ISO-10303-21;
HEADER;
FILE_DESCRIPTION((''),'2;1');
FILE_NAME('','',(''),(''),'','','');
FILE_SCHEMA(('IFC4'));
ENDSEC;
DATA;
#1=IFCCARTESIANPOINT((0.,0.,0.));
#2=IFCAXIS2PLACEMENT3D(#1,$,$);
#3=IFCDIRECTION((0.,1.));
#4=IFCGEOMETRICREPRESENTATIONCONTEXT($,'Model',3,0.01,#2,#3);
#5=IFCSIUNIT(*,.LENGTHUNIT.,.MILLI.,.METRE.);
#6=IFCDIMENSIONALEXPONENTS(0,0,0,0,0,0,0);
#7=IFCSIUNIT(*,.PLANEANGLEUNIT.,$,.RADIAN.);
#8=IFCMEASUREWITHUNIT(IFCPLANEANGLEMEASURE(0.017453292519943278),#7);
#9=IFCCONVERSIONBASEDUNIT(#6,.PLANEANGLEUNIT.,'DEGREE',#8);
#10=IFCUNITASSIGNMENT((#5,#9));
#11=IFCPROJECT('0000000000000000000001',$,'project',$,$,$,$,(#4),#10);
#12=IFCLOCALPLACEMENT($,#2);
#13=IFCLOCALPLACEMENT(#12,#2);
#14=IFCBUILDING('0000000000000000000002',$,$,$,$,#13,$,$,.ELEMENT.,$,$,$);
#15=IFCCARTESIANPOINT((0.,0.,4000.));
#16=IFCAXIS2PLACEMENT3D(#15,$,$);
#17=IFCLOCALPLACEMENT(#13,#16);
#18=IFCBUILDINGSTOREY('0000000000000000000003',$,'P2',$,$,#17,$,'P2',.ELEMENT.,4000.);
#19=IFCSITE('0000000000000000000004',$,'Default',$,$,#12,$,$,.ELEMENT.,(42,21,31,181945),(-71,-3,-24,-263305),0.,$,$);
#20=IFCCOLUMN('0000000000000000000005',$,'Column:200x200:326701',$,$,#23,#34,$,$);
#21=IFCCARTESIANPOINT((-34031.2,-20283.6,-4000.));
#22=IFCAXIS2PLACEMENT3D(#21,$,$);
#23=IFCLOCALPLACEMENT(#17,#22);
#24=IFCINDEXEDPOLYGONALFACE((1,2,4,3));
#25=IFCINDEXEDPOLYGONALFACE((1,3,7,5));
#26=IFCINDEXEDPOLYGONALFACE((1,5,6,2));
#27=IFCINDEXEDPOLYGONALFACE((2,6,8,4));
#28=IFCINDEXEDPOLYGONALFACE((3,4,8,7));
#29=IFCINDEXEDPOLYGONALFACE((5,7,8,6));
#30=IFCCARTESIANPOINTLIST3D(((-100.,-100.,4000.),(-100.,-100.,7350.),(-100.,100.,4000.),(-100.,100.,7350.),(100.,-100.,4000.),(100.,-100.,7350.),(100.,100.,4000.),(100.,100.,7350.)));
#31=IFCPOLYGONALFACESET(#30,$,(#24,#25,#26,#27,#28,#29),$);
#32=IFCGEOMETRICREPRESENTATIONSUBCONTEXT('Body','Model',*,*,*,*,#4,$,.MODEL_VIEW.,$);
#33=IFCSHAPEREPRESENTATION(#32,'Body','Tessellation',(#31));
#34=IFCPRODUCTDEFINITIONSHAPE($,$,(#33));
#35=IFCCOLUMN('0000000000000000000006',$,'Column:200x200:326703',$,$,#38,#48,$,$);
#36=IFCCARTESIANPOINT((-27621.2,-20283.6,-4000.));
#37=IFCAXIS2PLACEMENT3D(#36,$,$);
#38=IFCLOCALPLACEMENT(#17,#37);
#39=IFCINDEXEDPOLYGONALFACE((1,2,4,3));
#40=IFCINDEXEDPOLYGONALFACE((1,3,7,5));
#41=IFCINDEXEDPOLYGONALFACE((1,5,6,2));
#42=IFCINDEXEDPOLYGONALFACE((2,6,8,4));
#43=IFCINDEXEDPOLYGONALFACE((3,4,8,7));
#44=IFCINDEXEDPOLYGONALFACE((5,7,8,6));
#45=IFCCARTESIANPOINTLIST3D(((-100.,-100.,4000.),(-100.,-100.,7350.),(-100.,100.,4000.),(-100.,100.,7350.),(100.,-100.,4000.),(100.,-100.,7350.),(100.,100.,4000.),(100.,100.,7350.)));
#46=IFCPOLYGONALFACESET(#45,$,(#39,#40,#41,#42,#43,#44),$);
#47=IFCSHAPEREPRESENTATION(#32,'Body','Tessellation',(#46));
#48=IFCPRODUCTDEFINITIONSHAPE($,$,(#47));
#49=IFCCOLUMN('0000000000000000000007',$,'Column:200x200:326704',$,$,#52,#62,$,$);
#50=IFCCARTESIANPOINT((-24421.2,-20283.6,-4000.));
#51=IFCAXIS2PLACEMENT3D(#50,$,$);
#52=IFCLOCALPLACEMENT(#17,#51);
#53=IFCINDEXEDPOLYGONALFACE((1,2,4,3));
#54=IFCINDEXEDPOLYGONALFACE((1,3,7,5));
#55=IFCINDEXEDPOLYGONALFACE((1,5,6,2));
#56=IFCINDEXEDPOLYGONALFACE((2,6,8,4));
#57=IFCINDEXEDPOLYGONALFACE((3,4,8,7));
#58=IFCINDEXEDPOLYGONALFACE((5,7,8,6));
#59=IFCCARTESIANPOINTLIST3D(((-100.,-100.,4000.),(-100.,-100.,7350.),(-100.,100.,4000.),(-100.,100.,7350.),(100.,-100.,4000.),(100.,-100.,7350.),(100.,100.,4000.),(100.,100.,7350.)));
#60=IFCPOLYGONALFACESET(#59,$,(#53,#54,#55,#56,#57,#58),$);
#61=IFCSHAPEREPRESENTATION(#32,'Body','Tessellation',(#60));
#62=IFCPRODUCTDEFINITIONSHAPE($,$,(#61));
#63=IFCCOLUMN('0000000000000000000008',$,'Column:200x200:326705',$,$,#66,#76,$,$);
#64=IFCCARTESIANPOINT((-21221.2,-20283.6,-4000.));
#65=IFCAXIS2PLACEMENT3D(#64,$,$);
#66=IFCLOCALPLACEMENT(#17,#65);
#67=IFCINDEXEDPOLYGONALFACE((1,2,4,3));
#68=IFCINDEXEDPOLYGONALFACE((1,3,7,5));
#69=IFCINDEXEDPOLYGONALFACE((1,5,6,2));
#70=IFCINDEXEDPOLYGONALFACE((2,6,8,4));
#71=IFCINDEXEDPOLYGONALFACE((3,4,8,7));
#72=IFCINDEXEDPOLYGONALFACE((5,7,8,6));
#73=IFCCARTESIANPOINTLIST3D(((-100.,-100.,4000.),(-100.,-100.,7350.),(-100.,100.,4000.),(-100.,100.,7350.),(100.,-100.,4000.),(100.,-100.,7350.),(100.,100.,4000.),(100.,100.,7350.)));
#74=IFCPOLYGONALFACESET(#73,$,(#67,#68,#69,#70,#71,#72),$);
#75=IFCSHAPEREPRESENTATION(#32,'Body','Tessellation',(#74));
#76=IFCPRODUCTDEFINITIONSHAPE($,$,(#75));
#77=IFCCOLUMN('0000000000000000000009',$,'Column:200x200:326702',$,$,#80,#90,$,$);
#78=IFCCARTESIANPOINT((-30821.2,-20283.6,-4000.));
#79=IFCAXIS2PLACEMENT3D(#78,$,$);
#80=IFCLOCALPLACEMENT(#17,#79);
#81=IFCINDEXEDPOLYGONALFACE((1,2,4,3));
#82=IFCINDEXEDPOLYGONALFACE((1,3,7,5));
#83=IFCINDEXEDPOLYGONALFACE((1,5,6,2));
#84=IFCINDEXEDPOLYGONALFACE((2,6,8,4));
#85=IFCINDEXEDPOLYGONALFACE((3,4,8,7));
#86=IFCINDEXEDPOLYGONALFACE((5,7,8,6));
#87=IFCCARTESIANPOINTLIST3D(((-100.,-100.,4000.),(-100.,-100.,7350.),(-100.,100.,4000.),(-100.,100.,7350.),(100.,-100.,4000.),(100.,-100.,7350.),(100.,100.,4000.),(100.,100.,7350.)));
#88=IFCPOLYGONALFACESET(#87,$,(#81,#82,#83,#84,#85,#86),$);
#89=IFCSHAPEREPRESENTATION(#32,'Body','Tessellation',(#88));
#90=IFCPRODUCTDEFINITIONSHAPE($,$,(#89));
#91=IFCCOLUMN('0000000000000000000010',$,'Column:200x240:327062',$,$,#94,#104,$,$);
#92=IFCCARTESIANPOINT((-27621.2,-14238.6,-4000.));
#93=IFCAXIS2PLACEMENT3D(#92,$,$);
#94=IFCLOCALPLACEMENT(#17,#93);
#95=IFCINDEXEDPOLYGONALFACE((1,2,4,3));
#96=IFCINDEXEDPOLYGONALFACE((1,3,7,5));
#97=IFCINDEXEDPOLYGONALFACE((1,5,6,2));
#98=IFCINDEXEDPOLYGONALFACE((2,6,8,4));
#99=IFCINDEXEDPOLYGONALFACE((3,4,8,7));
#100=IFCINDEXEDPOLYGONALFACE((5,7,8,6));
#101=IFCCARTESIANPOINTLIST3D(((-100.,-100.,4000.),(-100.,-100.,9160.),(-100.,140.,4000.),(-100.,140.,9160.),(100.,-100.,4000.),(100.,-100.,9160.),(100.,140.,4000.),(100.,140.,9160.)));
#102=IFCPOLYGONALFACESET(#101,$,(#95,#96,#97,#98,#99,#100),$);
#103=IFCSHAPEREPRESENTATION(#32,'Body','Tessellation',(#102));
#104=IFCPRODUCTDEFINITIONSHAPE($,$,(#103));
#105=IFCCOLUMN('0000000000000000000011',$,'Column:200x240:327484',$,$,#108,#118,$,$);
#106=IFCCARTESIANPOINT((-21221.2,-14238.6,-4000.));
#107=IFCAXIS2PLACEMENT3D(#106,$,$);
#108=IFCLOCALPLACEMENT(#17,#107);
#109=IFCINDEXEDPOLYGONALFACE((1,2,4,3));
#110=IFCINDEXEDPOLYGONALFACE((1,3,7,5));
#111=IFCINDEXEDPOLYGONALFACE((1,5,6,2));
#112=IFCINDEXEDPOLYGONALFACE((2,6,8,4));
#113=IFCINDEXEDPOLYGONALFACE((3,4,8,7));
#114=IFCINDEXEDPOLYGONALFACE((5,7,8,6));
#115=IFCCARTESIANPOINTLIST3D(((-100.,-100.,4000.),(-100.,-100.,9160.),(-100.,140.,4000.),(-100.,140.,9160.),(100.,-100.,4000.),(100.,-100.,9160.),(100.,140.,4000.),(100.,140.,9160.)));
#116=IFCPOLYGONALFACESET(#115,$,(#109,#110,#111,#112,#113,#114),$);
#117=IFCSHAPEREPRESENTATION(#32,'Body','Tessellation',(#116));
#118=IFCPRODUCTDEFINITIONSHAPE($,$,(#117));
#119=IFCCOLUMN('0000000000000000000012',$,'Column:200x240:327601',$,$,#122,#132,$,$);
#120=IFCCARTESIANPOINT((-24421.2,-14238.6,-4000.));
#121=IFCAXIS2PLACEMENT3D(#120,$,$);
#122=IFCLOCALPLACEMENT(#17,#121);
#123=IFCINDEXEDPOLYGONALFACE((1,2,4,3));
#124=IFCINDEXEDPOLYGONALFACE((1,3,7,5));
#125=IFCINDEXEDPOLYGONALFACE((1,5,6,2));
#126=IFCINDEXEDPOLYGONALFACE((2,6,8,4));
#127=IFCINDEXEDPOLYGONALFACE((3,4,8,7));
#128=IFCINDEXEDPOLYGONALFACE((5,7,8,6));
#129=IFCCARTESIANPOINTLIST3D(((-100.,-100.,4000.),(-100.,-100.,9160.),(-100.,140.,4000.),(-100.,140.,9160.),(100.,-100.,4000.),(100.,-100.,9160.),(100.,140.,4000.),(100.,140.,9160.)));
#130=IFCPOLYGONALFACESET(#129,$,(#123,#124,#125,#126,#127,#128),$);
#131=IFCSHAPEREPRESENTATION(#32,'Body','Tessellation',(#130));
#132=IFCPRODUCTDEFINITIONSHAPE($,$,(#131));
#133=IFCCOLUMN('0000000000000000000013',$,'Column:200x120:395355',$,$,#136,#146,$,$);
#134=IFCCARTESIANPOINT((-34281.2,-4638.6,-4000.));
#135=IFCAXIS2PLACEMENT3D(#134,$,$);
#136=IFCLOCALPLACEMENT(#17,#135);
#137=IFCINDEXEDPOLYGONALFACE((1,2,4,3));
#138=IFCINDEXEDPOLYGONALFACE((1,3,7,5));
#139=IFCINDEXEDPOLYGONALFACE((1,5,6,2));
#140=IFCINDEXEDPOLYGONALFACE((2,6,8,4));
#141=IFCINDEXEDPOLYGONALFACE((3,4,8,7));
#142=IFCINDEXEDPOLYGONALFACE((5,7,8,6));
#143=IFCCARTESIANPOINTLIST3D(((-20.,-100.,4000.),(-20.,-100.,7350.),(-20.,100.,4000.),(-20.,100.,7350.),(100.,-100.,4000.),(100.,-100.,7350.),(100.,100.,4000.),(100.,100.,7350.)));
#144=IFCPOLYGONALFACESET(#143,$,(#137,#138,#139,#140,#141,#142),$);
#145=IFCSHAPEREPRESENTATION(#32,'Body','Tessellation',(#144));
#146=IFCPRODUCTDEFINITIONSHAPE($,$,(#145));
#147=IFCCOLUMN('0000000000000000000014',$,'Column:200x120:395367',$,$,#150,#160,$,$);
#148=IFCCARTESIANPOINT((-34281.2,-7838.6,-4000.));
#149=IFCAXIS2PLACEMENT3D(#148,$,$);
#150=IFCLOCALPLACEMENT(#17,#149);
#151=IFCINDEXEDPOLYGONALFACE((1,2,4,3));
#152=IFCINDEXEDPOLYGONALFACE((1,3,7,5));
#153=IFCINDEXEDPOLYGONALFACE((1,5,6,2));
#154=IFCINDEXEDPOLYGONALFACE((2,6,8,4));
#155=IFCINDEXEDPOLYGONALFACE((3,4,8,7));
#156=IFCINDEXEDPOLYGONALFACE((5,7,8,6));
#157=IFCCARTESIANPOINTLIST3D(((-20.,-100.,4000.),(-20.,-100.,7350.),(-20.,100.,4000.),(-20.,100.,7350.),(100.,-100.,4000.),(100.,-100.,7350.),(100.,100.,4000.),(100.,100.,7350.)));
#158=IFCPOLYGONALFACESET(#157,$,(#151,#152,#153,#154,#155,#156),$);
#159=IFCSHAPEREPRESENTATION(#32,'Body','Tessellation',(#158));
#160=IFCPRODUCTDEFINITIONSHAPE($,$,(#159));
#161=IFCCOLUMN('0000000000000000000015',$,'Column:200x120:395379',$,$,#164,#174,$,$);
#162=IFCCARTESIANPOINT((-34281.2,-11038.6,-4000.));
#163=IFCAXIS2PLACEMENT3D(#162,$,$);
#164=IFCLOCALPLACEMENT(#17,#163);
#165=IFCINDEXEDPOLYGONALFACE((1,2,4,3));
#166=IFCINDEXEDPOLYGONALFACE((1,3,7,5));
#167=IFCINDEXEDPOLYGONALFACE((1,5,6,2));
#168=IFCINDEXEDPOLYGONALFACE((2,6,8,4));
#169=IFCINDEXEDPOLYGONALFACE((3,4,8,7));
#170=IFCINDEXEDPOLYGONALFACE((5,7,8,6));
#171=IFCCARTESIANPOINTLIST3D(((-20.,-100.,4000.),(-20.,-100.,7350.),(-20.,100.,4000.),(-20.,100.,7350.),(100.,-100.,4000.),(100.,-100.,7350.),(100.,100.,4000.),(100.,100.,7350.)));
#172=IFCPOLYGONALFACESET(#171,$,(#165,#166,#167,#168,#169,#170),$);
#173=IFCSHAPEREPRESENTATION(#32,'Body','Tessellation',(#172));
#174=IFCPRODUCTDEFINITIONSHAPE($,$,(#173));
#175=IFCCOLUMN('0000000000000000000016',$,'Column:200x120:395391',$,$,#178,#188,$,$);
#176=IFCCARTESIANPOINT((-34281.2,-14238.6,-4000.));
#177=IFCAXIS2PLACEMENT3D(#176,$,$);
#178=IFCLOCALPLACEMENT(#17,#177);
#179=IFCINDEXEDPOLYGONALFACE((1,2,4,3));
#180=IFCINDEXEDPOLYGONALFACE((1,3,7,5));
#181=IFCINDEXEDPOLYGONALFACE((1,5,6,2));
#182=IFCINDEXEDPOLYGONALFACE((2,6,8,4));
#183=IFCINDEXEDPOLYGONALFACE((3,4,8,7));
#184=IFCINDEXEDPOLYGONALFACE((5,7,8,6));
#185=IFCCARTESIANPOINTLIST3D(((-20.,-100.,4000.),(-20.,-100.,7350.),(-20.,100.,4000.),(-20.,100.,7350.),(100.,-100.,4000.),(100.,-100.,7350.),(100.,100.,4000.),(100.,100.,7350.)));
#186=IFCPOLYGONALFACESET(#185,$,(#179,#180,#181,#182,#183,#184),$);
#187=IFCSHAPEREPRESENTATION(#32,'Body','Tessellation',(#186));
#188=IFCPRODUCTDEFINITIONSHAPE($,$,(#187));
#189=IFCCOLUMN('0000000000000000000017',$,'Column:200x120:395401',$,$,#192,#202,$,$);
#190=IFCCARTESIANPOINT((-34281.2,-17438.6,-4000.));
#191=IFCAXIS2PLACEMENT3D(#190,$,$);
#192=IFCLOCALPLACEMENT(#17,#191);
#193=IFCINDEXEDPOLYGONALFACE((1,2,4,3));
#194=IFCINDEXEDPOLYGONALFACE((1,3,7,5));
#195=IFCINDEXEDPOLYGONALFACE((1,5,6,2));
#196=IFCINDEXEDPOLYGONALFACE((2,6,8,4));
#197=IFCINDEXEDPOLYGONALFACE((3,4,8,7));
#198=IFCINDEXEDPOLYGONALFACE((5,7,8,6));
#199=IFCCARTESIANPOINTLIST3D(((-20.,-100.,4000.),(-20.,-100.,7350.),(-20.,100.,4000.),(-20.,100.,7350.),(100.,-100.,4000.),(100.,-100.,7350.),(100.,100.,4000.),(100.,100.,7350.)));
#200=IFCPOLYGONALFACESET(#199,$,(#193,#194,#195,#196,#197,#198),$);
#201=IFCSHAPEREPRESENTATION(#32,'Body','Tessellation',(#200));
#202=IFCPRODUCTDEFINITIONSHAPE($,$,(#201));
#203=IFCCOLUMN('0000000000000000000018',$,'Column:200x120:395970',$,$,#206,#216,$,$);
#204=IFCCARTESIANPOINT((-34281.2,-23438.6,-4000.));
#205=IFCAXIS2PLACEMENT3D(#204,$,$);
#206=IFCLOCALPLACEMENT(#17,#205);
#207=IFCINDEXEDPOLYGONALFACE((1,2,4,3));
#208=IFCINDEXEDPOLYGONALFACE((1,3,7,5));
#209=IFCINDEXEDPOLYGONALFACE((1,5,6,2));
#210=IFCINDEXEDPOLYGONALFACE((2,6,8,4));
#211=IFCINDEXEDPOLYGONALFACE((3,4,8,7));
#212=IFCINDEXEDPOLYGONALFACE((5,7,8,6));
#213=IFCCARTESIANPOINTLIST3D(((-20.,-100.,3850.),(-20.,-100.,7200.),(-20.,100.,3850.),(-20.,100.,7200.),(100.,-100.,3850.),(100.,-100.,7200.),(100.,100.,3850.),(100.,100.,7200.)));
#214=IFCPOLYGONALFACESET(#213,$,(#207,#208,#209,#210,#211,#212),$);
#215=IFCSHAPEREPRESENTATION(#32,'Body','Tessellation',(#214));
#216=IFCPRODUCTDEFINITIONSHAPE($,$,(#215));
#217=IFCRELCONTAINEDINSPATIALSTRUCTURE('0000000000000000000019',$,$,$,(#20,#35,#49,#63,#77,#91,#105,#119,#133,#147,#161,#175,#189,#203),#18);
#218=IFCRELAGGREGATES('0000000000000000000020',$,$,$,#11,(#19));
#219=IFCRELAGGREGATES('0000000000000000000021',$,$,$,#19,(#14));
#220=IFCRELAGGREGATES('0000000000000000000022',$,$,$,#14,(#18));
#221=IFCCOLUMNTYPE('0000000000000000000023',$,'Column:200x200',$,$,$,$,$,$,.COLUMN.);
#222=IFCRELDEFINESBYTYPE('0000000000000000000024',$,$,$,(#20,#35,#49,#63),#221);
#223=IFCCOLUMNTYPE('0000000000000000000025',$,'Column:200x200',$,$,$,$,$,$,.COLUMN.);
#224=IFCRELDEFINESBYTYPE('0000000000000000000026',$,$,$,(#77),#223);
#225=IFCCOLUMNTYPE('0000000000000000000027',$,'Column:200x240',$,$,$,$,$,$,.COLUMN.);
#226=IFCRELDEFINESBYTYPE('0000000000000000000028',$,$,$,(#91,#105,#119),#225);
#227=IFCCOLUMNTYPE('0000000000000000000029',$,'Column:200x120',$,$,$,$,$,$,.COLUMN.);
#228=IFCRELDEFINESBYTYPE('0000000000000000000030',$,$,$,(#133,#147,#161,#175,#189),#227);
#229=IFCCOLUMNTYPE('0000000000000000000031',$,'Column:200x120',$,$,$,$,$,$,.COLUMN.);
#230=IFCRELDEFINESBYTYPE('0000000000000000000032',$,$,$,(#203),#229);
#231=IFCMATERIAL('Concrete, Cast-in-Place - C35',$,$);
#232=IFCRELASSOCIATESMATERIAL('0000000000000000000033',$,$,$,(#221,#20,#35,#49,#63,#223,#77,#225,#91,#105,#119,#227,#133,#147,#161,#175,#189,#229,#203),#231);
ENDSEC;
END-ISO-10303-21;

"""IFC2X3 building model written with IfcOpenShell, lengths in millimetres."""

from ifc_helpers import new_model, entity, si_unit, converted_unit, direction, frame, frame_2d, origin, origin_2d_with_axis, place, context, subcontext, project, spatial, rectangle, extrude, source, transform, mapped, material, type_object, type_shapes, element, save


model = new_model("IFC2X3")

# Units and contexts
model_context = context("Model", 3, precision=0.01, world=origin(), true_north=direction((0.0, 1.0)))
body_context = subcontext(model_context, "Body", "Model", "MODEL_VIEW")
ifc_project = project(units=[si_unit("LENGTHUNIT", "METRE", prefix="MILLI"), converted_unit("PLANEANGLEUNIT", "DEGREE", entity("IfcPlaneAngleMeasure", 0.017453292519943278), si_unit("PLANEANGLEUNIT", "RADIAN"), dimensions=[0, 0, 0, 0, 0, 0, 0])], contexts=[model_context])

# Site, building, storey
site_placement = place(None, origin())
site = spatial("IfcSite", under=ifc_project, at=site_placement, Name="Default", CompositionType="ELEMENT", RefLatitude=(42, 21, 31, 181945), RefLongitude=(-71, -3, -24, -263305), RefElevation=0.0)
building_placement = place(site_placement, origin())
building = spatial("IfcBuilding", under=site, at=building_placement, CompositionType="ELEMENT")
storey_placement = place(building_placement, frame((0.0, 0.0, 4000.0)))
storey = spatial("IfcBuildingStorey", under=building, at=storey_placement, Name="P2", LongName="P2", CompositionType="ELEMENT", Elevation=4000.0)

# Columns
ifc_material_1 = material(Name="Concrete, Cast-in-Place - C35")
column_type_1 = type_object("IfcColumnType", Name="Column:200x200", PredefinedType="COLUMN", material=ifc_material_1)
shared_shape_1 = source(origin(), body_context, "Body", "SweptSolid", [
    extrude(rectangle(XDim=200.0, YDim=200.0, at=frame_2d((0.0, 0.0), x_axis=(1.0, 0.0))), frame((0.0, 0.0, 4000.0), z_axis=(0.0, 0.0, 1.0), x_axis=(-1.0, 0.0, 0.0)), (0.0, 0.0, 1.0), 3350.0),
])
type_shapes(column_type_1, [shared_shape_1])
for number, where, name in (
    (1, (-34031.2, -20283.6, -4000.0), "Column:200x200:326701"),
    (2, (-27621.2, -20283.6, -4000.0), "Column:200x200:326703"),
    (3, (-24421.2, -20283.6, -4000.0), "Column:200x200:326704"),
    (4, (-21221.2, -20283.6, -4000.0), "Column:200x200:326705"),
):
    element("IfcColumn", number, at=place(storey_placement, frame(where)), inside=storey, type_object=column_type_1, material=ifc_material_1, Name=name, context=body_context, shape_type="MappedRepresentation", body=[
        mapped(shared_shape_1, transform((0.0, 0.0, 0.0), scale=1.0)),
    ])
column_type_2 = type_object("IfcColumnType", Name="Column:200x200", PredefinedType="COLUMN", material=ifc_material_1)
shared_shape_2 = source(origin(), body_context, "Body", "SweptSolid", [
    extrude(rectangle(XDim=200.0, YDim=200.0, at=frame_2d((0.0, 0.0), x_axis=(1.0, 0.0))), frame((0.0, 0.0, 4000.0), z_axis=(0.0, 0.0, 1.0), x_axis=(-1.0, 0.0, 0.0)), (0.0, 0.0, 1.0), 3350.0),
])
type_shapes(column_type_2, [shared_shape_2])
column_1_placement = place(storey_placement, frame((-30821.2, -20283.6, -4000.0)))
element("IfcColumn", 5, at=column_1_placement, inside=storey, type_object=column_type_2, material=ifc_material_1, Name="Column:200x200:326702", context=body_context, shape_type="MappedRepresentation", body=[
    mapped(shared_shape_2, transform((0.0, 0.0, 0.0), scale=1.0)),
])
column_type_3 = type_object("IfcColumnType", Name="Column:200x240", PredefinedType="COLUMN", material=ifc_material_1)
shared_shape_3 = source(origin(), body_context, "Body", "SweptSolid", [
    extrude(rectangle(XDim=200.0, YDim=240.0, at=origin_2d_with_axis()), frame((0.0, 20.0, 4000.0), z_axis=(0.0, 0.0, 1.0), x_axis=(-1.0, 0.0, 0.0)), (0.0, 0.0, 1.0), 5160.0),
])
type_shapes(column_type_3, [shared_shape_3])
for number, where, name in (
    (6, (-27621.2, -14238.6, -4000.0), "Column:200x240:327062"),
    (7, (-21221.2, -14238.6, -4000.0), "Column:200x240:327484"),
    (8, (-24421.2, -14238.6, -4000.0), "Column:200x240:327601"),
):
    element("IfcColumn", number, at=place(storey_placement, frame(where)), inside=storey, type_object=column_type_3, material=ifc_material_1, Name=name, context=body_context, shape_type="MappedRepresentation", body=[
        mapped(shared_shape_3, transform((0.0, 0.0, 0.0), scale=1.0)),
    ])
column_type_4 = type_object("IfcColumnType", Name="Column:200x120", PredefinedType="COLUMN", material=ifc_material_1)
shared_shape_4 = source(origin(), body_context, "Body", "SweptSolid", [
    extrude(rectangle(XDim=120.0, YDim=200.0, at=origin_2d_with_axis()), frame((40.0, 0.0, 4000.0), z_axis=(0.0, 0.0, 1.0), x_axis=(-1.0, 0.0, 0.0)), (0.0, 0.0, 1.0), 3350.0),
])
type_shapes(column_type_4, [shared_shape_4])
for number, where, name in (
    (9, (-34281.2, -4638.6, -4000.0), "Column:200x120:395355"),
    (10, (-34281.2, -7838.6, -4000.0), "Column:200x120:395367"),
    (11, (-34281.2, -11038.6, -4000.0), "Column:200x120:395379"),
    (12, (-34281.2, -14238.6, -4000.0), "Column:200x120:395391"),
    (13, (-34281.2, -17438.6, -4000.0), "Column:200x120:395401"),
):
    element("IfcColumn", number, at=place(storey_placement, frame(where)), inside=storey, type_object=column_type_4, material=ifc_material_1, Name=name, context=body_context, shape_type="MappedRepresentation", body=[
        mapped(shared_shape_4, transform((0.0, 0.0, 0.0), scale=1.0)),
    ])
column_type_5 = type_object("IfcColumnType", Name="Column:200x120", PredefinedType="COLUMN", material=ifc_material_1)
shared_shape_5 = source(origin(), body_context, "Body", "SweptSolid", [
    extrude(rectangle(XDim=120.0, YDim=200.0, at=origin_2d_with_axis()), frame((40.0, 0.0, 3850.0), z_axis=(0.0, 0.0, 1.0), x_axis=(-1.0, 0.0, 0.0)), (0.0, 0.0, 1.0), 3350.0),
])
type_shapes(column_type_5, [shared_shape_5])
column_2_placement = place(storey_placement, frame((-34281.2, -23438.6, -4000.0)))
element("IfcColumn", 14, at=column_2_placement, inside=storey, type_object=column_type_5, material=ifc_material_1, Name="Column:200x120:395970", context=body_context, shape_type="MappedRepresentation", body=[
    mapped(shared_shape_5, transform((0.0, 0.0, 0.0), scale=1.0)),
])

save(model, "model.ifc")
